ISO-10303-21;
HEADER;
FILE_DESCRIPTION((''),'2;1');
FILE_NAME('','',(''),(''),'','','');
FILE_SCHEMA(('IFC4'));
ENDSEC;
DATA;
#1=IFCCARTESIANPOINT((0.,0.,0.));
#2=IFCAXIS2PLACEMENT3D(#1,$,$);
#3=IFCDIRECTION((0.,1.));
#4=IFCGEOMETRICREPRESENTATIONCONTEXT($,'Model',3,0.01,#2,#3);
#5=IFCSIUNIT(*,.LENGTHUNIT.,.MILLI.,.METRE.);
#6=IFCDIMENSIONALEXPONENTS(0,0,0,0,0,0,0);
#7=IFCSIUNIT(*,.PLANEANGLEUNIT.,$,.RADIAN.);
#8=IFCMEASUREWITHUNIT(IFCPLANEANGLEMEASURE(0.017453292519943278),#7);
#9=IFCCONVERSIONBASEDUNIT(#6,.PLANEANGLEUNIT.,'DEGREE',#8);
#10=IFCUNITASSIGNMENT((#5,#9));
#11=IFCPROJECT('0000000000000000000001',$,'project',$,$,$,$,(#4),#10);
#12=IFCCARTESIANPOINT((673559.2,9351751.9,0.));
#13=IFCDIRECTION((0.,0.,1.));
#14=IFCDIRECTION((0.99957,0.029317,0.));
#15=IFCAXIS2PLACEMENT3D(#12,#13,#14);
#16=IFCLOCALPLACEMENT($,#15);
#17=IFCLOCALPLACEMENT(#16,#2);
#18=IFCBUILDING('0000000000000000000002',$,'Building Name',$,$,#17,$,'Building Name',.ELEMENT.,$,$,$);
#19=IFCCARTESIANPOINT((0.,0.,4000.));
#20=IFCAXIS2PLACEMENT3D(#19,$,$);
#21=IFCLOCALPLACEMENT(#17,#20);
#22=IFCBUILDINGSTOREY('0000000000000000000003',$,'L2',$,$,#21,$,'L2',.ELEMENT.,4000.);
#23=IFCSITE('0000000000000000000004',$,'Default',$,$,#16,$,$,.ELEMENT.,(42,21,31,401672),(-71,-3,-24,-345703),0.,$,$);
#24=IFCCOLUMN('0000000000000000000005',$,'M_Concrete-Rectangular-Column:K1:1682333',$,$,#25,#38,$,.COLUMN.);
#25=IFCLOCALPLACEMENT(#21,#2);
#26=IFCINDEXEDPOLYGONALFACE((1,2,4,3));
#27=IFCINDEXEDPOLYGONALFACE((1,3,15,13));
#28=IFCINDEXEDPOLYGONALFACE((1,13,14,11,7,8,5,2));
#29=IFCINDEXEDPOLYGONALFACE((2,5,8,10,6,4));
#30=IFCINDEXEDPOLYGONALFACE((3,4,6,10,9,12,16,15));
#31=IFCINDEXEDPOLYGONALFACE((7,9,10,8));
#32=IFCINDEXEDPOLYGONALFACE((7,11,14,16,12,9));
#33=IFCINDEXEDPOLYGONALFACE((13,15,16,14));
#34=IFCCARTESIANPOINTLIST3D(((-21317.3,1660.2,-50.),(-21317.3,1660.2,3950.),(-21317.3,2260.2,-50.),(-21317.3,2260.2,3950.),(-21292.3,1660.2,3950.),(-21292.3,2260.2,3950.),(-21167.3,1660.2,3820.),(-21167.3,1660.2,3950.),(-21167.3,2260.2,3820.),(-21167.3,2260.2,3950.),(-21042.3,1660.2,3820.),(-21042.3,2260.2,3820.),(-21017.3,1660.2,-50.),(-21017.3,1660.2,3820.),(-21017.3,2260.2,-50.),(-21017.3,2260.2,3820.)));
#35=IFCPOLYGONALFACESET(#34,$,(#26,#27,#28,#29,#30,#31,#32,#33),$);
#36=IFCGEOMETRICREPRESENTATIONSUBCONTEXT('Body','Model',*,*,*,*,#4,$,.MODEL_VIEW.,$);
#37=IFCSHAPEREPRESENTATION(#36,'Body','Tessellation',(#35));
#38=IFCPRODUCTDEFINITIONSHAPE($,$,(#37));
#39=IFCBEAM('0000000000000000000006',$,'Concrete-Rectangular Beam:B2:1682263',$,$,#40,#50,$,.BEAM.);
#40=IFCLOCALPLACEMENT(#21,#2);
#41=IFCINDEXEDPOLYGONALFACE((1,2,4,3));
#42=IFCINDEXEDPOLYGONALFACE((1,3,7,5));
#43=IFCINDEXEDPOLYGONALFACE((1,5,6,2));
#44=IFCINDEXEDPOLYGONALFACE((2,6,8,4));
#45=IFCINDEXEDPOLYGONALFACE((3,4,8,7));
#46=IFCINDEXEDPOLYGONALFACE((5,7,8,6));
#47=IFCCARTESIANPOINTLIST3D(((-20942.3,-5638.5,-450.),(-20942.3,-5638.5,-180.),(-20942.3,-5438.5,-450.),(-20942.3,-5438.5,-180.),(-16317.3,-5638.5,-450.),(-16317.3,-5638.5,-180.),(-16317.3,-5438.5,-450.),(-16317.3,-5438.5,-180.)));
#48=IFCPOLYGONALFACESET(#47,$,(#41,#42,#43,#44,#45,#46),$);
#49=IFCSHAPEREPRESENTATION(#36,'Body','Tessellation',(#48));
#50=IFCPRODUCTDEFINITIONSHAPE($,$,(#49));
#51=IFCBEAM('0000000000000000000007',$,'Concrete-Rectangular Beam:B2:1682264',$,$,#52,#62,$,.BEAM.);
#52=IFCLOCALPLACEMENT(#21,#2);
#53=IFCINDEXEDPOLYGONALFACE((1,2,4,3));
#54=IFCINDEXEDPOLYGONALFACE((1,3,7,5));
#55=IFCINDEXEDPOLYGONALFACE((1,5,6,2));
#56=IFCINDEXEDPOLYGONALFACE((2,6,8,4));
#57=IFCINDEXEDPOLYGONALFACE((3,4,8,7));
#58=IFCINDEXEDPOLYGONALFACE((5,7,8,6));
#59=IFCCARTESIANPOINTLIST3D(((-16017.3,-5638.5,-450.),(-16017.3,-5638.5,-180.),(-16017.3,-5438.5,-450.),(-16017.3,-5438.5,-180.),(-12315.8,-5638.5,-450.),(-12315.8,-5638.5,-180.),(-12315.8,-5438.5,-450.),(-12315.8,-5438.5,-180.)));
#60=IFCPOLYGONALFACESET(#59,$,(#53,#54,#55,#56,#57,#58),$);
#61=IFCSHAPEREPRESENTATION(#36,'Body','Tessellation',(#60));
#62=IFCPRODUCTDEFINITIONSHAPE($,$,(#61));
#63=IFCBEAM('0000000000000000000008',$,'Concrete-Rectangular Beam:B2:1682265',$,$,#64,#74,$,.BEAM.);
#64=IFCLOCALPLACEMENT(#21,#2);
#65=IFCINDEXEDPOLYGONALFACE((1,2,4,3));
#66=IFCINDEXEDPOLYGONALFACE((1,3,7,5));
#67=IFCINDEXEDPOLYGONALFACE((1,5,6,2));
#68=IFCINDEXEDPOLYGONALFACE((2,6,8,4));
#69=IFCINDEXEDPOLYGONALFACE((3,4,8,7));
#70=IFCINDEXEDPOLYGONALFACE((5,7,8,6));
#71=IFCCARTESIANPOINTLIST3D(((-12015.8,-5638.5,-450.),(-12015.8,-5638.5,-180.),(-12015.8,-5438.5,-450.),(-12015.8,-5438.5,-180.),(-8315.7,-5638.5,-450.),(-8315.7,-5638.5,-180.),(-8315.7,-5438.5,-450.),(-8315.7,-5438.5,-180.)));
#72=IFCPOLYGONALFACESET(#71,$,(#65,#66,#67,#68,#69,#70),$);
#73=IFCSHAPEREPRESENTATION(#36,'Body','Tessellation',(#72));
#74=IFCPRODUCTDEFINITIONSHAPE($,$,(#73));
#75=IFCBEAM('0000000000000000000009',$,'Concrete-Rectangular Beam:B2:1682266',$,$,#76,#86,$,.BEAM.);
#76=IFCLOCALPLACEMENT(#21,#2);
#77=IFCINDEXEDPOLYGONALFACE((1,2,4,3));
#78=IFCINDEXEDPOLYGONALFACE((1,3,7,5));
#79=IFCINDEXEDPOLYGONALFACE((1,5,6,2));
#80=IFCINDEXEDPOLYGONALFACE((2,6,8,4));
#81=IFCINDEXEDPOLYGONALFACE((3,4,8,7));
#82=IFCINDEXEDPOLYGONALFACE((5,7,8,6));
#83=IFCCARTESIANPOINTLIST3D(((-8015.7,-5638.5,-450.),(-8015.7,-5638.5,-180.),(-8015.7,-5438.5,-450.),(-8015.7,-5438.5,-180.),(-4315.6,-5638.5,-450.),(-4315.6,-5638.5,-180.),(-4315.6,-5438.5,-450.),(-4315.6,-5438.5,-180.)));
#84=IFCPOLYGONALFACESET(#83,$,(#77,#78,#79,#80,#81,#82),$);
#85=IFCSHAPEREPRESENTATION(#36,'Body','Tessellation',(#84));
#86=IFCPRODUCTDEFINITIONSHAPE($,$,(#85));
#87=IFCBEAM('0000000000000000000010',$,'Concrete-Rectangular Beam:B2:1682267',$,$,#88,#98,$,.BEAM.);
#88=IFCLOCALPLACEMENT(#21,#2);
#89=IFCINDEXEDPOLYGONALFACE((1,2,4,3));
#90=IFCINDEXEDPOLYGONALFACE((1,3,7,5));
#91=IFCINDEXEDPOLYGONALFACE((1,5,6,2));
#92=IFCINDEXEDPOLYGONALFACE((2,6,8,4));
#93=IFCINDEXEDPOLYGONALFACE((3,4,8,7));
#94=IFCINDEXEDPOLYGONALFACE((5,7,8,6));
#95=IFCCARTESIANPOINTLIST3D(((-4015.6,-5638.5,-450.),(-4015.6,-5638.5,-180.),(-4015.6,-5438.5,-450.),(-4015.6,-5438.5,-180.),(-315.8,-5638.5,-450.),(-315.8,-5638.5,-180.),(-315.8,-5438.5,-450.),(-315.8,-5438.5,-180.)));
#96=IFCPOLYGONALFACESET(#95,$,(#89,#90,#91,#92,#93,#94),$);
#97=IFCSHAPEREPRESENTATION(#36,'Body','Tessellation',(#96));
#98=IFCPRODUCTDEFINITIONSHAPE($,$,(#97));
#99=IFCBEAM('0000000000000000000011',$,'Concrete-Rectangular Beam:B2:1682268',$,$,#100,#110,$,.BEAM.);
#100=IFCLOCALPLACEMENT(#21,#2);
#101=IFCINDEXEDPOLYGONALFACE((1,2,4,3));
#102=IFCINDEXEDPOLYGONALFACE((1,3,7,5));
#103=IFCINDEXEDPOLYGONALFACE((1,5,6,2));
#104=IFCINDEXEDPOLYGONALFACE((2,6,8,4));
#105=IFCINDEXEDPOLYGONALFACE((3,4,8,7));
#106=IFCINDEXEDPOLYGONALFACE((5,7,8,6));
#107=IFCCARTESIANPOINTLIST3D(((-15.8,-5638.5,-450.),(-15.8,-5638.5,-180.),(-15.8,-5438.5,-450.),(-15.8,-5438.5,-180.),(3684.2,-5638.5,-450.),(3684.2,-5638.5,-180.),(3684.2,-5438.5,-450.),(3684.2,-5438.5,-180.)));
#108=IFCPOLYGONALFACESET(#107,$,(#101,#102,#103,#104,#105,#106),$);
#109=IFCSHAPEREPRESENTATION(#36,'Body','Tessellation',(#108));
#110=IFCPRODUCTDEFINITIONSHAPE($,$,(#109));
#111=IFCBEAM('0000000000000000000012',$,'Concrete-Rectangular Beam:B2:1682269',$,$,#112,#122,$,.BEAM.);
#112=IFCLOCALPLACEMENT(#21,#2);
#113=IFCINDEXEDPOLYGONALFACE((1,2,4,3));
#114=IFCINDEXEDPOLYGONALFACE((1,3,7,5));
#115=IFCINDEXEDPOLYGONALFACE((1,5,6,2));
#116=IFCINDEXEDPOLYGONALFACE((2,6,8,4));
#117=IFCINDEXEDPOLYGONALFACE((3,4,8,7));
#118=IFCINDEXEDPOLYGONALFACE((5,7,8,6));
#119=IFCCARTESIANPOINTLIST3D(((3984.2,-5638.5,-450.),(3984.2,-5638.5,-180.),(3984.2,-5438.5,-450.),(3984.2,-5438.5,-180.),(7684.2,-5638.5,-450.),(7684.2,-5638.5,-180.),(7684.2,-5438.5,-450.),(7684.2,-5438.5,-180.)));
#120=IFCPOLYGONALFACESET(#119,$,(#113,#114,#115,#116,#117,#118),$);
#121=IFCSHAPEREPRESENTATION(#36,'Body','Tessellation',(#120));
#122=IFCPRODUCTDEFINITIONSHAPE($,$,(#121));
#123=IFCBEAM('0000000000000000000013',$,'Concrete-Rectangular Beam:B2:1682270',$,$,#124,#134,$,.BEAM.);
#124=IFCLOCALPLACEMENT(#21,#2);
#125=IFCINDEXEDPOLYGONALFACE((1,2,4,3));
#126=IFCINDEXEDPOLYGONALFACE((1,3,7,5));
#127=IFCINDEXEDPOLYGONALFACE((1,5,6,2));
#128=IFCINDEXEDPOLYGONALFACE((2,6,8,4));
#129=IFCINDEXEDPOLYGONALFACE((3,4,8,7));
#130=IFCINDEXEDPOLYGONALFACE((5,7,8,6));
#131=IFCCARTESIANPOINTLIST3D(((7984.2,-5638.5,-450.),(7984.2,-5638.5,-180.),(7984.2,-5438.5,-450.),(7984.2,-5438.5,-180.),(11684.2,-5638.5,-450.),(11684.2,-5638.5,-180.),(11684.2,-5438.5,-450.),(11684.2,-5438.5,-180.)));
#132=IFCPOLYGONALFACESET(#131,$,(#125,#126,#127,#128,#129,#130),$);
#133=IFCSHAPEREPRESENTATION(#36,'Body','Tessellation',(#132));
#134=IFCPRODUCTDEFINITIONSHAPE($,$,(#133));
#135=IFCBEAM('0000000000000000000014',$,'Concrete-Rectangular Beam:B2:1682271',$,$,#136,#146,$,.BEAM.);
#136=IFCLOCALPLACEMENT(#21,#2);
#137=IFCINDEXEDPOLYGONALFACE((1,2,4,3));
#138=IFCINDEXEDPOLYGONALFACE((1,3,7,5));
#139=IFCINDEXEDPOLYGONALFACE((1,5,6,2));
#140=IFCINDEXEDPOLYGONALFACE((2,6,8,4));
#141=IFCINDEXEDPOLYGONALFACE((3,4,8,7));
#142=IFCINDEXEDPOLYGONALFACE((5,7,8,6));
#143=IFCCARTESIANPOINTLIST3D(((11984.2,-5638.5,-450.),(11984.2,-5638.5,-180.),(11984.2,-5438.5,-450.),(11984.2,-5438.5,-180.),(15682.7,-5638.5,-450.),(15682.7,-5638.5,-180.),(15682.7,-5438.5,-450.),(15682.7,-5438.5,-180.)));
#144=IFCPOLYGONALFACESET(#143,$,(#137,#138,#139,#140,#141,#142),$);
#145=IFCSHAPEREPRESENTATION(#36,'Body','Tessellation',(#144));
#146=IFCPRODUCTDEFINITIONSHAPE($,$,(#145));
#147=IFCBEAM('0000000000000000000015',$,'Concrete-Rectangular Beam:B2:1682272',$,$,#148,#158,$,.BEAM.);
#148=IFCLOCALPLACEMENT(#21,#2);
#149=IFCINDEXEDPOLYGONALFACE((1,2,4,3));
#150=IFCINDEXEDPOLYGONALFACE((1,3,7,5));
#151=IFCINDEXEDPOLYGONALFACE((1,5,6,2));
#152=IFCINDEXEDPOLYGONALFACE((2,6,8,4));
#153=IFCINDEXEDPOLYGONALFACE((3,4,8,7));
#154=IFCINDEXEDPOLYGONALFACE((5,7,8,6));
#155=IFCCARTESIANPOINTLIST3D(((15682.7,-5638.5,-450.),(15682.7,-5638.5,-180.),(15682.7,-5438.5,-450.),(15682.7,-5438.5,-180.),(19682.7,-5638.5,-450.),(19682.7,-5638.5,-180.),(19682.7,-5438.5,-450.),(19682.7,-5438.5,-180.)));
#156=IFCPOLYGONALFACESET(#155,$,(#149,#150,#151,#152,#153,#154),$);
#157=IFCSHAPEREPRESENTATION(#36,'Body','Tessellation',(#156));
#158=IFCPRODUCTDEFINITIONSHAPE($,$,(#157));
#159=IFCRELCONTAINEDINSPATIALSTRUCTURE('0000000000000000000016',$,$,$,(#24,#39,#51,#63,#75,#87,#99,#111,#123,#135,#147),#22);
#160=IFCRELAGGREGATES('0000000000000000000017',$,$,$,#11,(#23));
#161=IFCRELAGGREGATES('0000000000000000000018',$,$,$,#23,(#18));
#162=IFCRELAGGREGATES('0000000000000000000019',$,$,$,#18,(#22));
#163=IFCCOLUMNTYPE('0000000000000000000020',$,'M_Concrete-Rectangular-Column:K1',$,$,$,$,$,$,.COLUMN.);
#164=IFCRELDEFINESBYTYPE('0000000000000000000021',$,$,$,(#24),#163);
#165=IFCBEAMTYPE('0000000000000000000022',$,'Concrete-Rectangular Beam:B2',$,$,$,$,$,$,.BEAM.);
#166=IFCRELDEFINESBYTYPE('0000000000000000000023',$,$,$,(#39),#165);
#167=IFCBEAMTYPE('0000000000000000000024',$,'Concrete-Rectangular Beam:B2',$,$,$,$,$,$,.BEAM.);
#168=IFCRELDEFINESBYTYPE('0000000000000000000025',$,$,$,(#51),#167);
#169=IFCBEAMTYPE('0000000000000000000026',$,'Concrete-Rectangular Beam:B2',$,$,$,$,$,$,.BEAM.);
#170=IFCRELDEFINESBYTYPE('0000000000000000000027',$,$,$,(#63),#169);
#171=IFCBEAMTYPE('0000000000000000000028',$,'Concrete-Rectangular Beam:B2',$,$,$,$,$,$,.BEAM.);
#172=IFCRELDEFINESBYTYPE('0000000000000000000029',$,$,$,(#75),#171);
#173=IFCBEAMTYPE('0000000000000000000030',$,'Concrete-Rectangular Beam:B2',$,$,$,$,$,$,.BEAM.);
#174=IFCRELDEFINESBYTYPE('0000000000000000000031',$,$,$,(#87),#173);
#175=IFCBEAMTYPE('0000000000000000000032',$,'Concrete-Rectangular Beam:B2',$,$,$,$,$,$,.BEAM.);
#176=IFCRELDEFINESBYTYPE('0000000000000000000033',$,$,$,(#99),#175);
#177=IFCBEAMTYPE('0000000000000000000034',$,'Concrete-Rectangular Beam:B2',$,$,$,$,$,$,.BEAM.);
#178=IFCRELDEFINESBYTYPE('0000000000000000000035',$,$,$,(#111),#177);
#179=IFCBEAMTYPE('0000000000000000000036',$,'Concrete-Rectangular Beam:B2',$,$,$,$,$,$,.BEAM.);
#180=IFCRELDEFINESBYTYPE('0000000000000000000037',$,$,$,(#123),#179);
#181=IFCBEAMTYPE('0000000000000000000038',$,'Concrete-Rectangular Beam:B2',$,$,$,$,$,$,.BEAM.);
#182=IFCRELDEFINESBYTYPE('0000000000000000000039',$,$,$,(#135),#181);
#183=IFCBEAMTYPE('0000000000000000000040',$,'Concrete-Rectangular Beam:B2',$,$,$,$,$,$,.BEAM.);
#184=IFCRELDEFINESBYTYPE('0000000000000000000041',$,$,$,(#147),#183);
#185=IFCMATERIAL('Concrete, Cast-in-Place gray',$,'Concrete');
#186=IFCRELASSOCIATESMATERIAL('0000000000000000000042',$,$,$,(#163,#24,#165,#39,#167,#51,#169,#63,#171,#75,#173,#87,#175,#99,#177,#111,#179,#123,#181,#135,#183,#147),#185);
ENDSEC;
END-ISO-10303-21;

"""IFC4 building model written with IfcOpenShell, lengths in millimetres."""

from ifc_helpers import new_model, entity, si_unit, converted_unit, direction, frame, origin, place, context, subcontext, project, spatial, indexed_curve, outline, extrude, source, transform, mapped, material, type_object, type_shapes, element, save


model = new_model("IFC4")

# Units and contexts
model_context = context("Model", 3, precision=0.01, world=origin(), true_north=direction((0.0, 1.0)))
body_context = subcontext(model_context, "Body", "Model", "MODEL_VIEW")
ifc_project = project(units=[si_unit("LENGTHUNIT", "METRE", prefix="MILLI"), converted_unit("PLANEANGLEUNIT", "DEGREE", entity("IfcPlaneAngleMeasure", 0.017453292519943278), si_unit("PLANEANGLEUNIT", "RADIAN"), dimensions=[0, 0, 0, 0, 0, 0, 0])], contexts=[model_context])

# Site, building, storey
site_placement = place(None, frame((673559.2, 9351751.9, 0.0), z_axis=(0.0, 0.0, 1.0), x_axis=(0.99957, 0.029317, 0.0)))
site = spatial("IfcSite", under=ifc_project, at=site_placement, Name="Default", CompositionType="ELEMENT", RefLatitude=(42, 21, 31, 401672), RefLongitude=(-71, -3, -24, -345703), RefElevation=0.0)
building_placement = place(site_placement, origin())
building = spatial("IfcBuilding", under=site, at=building_placement, Name="Building Name", LongName="Building Name", CompositionType="ELEMENT")
storey_placement = place(building_placement, frame((0.0, 0.0, 4000.0)))
storey = spatial("IfcBuildingStorey", under=building, at=storey_placement, Name="L2", LongName="L2", CompositionType="ELEMENT", Elevation=4000.0)

# Column
ifc_material = material(Name="Concrete, Cast-in-Place gray", Category="Concrete")
column_type = type_object("IfcColumnType", Name="M_Concrete-Rectangular-Column:K1", PredefinedType="COLUMN", material=ifc_material)
shared_shape_1 = source(origin(), body_context, "Body", "SweptSolid", [
    extrude(outline(indexed_curve([(-2951.3, -150.0), (1048.7, -150.0), (1048.7, -125.0), (1048.7, 0.0), (918.8, 0.0), (918.8, 125.0), (918.8, 150.0), (-2951.3, 150.0), (-2951.3, -150.0)], self_intersect=False)), frame((-21167.3, 1660.2, 6901.3), z_axis=(0.0, 1.0, 0.0), x_axis=(0.0, 0.0, 1.0)), (0.0, 0.0, 1.0), 600.0),
])
type_shapes(column_type, [shared_shape_1])
column_placement = place(storey_placement, frame((0.0, 0.0, -4000.0)))
element("IfcColumn", 1, at=column_placement, inside=storey, type_object=column_type, material=ifc_material, Name="M_Concrete-Rectangular-Column:K1:1682333", PredefinedType="COLUMN", context=body_context, shape_type="MappedRepresentation", body=[
    mapped(shared_shape_1, transform((0.0, 0.0, 0.0), scale=1.0)),
])

# Beams
beam_type_1 = type_object("IfcBeamType", Name="Concrete-Rectangular Beam:B2", PredefinedType="BEAM", material=ifc_material)
shared_shape_2 = source(origin(), body_context, "Body", "SweptSolid", [
    extrude(outline(indexed_curve([(-135.0, -100.0), (135.0, -100.0), (135.0, 100.0), (-135.0, 100.0), (-135.0, -100.0)], self_intersect=False)), frame((-20942.3, -5538.5, 3685.0), z_axis=(1.0, 0.0, 0.0), x_axis=(0.0, 0.0, -1.0)), (0.0, 0.0, 1.0), 4625.0),
])
type_shapes(beam_type_1, [shared_shape_2])
beam_1_placement = place(storey_placement, frame((0.0, 0.0, -4000.0)))
element("IfcBeam", 2, at=beam_1_placement, inside=storey, type_object=beam_type_1, material=ifc_material, Name="Concrete-Rectangular Beam:B2:1682263", PredefinedType="BEAM", context=body_context, shape_type="MappedRepresentation", body=[
    mapped(shared_shape_2, transform((0.0, 0.0, 0.0), scale=1.0)),
])
beam_type_2 = type_object("IfcBeamType", Name="Concrete-Rectangular Beam:B2", PredefinedType="BEAM", material=ifc_material)
shared_shape_3 = source(origin(), body_context, "Body", "SweptSolid", [
    extrude(outline(indexed_curve([(-135.0, -100.0), (135.0, -100.0), (135.0, 100.0), (-135.0, 100.0), (-135.0, -100.0)], self_intersect=False)), frame((-16017.3, -5538.5, 3685.0), z_axis=(1.0, 0.0, 0.0), x_axis=(0.0, 0.0, -1.0)), (0.0, 0.0, 1.0), 3701.5),
])
type_shapes(beam_type_2, [shared_shape_3])
beam_2_placement = place(storey_placement, frame((0.0, 0.0, -4000.0)))
element("IfcBeam", 3, at=beam_2_placement, inside=storey, type_object=beam_type_2, material=ifc_material, Name="Concrete-Rectangular Beam:B2:1682264", PredefinedType="BEAM", context=body_context, shape_type="MappedRepresentation", body=[
    mapped(shared_shape_3, transform((0.0, 0.0, 0.0), scale=1.0)),
])
beam_type_3 = type_object("IfcBeamType", Name="Concrete-Rectangular Beam:B2", PredefinedType="BEAM", material=ifc_material)
shared_shape_4 = source(origin(), body_context, "Body", "SweptSolid", [
    extrude(outline(indexed_curve([(-135.0, -100.0), (135.0, -100.0), (135.0, 100.0), (-135.0, 100.0), (-135.0, -100.0)], self_intersect=False)), frame((-8315.7, -5538.5, 3685.0), z_axis=(-1.0, 0.0, 0.0), x_axis=(0.0, 0.0, -1.0)), (0.0, 0.0, 1.0), 3700.1),
])
type_shapes(beam_type_3, [shared_shape_4])
beam_3_placement = place(storey_placement, frame((0.0, 0.0, -4000.0)))
element("IfcBeam", 4, at=beam_3_placement, inside=storey, type_object=beam_type_3, material=ifc_material, Name="Concrete-Rectangular Beam:B2:1682265", PredefinedType="BEAM", context=body_context, shape_type="MappedRepresentation", body=[
    mapped(shared_shape_4, transform((0.0, 0.0, 0.0), scale=1.0)),
])
beam_type_4 = type_object("IfcBeamType", Name="Concrete-Rectangular Beam:B2", PredefinedType="BEAM", material=ifc_material)
shared_shape_5 = source(origin(), body_context, "Body", "SweptSolid", [
    extrude(outline(indexed_curve([(-135.0, -100.0), (135.0, -100.0), (135.0, 100.0), (-135.0, 100.0), (-135.0, -100.0)], self_intersect=False)), frame((-8015.7, -5538.5, 3685.0), z_axis=(1.0, 0.0, 0.0), x_axis=(0.0, 0.0, -1.0)), (0.0, 0.0, 1.0), 3700.1),
])
type_shapes(beam_type_4, [shared_shape_5])
beam_4_placement = place(storey_placement, frame((0.0, 0.0, -4000.0)))
element("IfcBeam", 5, at=beam_4_placement, inside=storey, type_object=beam_type_4, material=ifc_material, Name="Concrete-Rectangular Beam:B2:1682266", PredefinedType="BEAM", context=body_context, shape_type="MappedRepresentation", body=[
    mapped(shared_shape_5, transform((0.0, 0.0, 0.0), scale=1.0)),
])
beam_type_5 = type_object("IfcBeamType", Name="Concrete-Rectangular Beam:B2", PredefinedType="BEAM", material=ifc_material)
shared_shape_6 = source(origin(), body_context, "Body", "SweptSolid", [
    extrude(outline(indexed_curve([(-135.0, -100.0), (135.0, -100.0), (135.0, 100.0), (-135.0, 100.0), (-135.0, -100.0)], self_intersect=False)), frame((-4015.6, -5538.5, 3685.0), z_axis=(1.0, 0.0, 0.0), x_axis=(0.0, 0.0, -1.0)), (0.0, 0.0, 1.0), 3699.7),
])
type_shapes(beam_type_5, [shared_shape_6])
beam_5_placement = place(storey_placement, frame((0.0, 0.0, -4000.0)))
element("IfcBeam", 6, at=beam_5_placement, inside=storey, type_object=beam_type_5, material=ifc_material, Name="Concrete-Rectangular Beam:B2:1682267", PredefinedType="BEAM", context=body_context, shape_type="MappedRepresentation", body=[
    mapped(shared_shape_6, transform((0.0, 0.0, 0.0), scale=1.0)),
])
beam_type_6 = type_object("IfcBeamType", Name="Concrete-Rectangular Beam:B2", PredefinedType="BEAM", material=ifc_material)
shared_shape_7 = source(origin(), body_context, "Body", "SweptSolid", [
    extrude(outline(indexed_curve([(-135.0, -100.0), (135.0, -100.0), (135.0, 100.0), (-135.0, 100.0), (-135.0, -100.0)], self_intersect=False)), frame((-15.8, -5538.5, 3685.0), z_axis=(1.0, 0.0, 0.0), x_axis=(0.0, 0.0, -1.0)), (0.0, 0.0, 1.0), 3700.0),
])
type_shapes(beam_type_6, [shared_shape_7])
beam_6_placement = place(storey_placement, frame((0.0, 0.0, -4000.0)))
element("IfcBeam", 7, at=beam_6_placement, inside=storey, type_object=beam_type_6, material=ifc_material, Name="Concrete-Rectangular Beam:B2:1682268", PredefinedType="BEAM", context=body_context, shape_type="MappedRepresentation", body=[
    mapped(shared_shape_7, transform((0.0, 0.0, 0.0), scale=1.0)),
])
beam_type_7 = type_object("IfcBeamType", Name="Concrete-Rectangular Beam:B2", PredefinedType="BEAM", material=ifc_material)
shared_shape_8 = source(origin(), body_context, "Body", "SweptSolid", [
    extrude(outline(indexed_curve([(-135.0, -100.0), (135.0, -100.0), (135.0, 100.0), (-135.0, 100.0), (-135.0, -100.0)], self_intersect=False)), frame((3984.2, -5538.5, 3685.0), z_axis=(1.0, 0.0, 0.0), x_axis=(0.0, 0.0, -1.0)), (0.0, 0.0, 1.0), 3700.0),
])
type_shapes(beam_type_7, [shared_shape_8])
beam_7_placement = place(storey_placement, frame((0.0, 0.0, -4000.0)))
element("IfcBeam", 8, at=beam_7_placement, inside=storey, type_object=beam_type_7, material=ifc_material, Name="Concrete-Rectangular Beam:B2:1682269", PredefinedType="BEAM", context=body_context, shape_type="MappedRepresentation", body=[
    mapped(shared_shape_8, transform((0.0, 0.0, 0.0), scale=1.0)),
])
beam_type_8 = type_object("IfcBeamType", Name="Concrete-Rectangular Beam:B2", PredefinedType="BEAM", material=ifc_material)
shared_shape_9 = source(origin(), body_context, "Body", "SweptSolid", [
    extrude(outline(indexed_curve([(-135.0, -100.0), (135.0, -100.0), (135.0, 100.0), (-135.0, 100.0), (-135.0, -100.0)], self_intersect=False)), frame((7984.2, -5538.5, 3685.0), z_axis=(1.0, 0.0, 0.0), x_axis=(0.0, 0.0, -1.0)), (0.0, 0.0, 1.0), 3700.0),
])
type_shapes(beam_type_8, [shared_shape_9])
beam_8_placement = place(storey_placement, frame((0.0, 0.0, -4000.0)))
element("IfcBeam", 9, at=beam_8_placement, inside=storey, type_object=beam_type_8, material=ifc_material, Name="Concrete-Rectangular Beam:B2:1682270", PredefinedType="BEAM", context=body_context, shape_type="MappedRepresentation", body=[
    mapped(shared_shape_9, transform((0.0, 0.0, 0.0), scale=1.0)),
])
beam_type_9 = type_object("IfcBeamType", Name="Concrete-Rectangular Beam:B2", PredefinedType="BEAM", material=ifc_material)
shared_shape_10 = source(origin(), body_context, "Body", "SweptSolid", [
    extrude(outline(indexed_curve([(-135.0, -100.0), (135.0, -100.0), (135.0, 100.0), (-135.0, 100.0), (-135.0, -100.0)], self_intersect=False)), frame((11984.2, -5538.5, 3685.0), z_axis=(1.0, 0.0, 0.0), x_axis=(0.0, 0.0, -1.0)), (0.0, 0.0, 1.0), 3698.5),
])
type_shapes(beam_type_9, [shared_shape_10])
beam_9_placement = place(storey_placement, frame((0.0, 0.0, -4000.0)))
element("IfcBeam", 10, at=beam_9_placement, inside=storey, type_object=beam_type_9, material=ifc_material, Name="Concrete-Rectangular Beam:B2:1682271", PredefinedType="BEAM", context=body_context, shape_type="MappedRepresentation", body=[
    mapped(shared_shape_10, transform((0.0, 0.0, 0.0), scale=1.0)),
])
beam_type_10 = type_object("IfcBeamType", Name="Concrete-Rectangular Beam:B2", PredefinedType="BEAM", material=ifc_material)
shared_shape_11 = source(origin(), body_context, "Body", "SweptSolid", [
    extrude(outline(indexed_curve([(-135.0, -100.0), (135.0, -100.0), (135.0, 100.0), (-135.0, 100.0), (-135.0, -100.0)], self_intersect=False)), frame((15682.7, -5538.5, 3685.0), z_axis=(1.0, 0.0, 0.0), x_axis=(0.0, 0.0, -1.0)), (0.0, 0.0, 1.0), 4000.0),
])
type_shapes(beam_type_10, [shared_shape_11])
beam_10_placement = place(storey_placement, frame((0.0, 0.0, -4000.0)))
element("IfcBeam", 11, at=beam_10_placement, inside=storey, type_object=beam_type_10, material=ifc_material, Name="Concrete-Rectangular Beam:B2:1682272", PredefinedType="BEAM", context=body_context, shape_type="MappedRepresentation", body=[
    mapped(shared_shape_11, transform((0.0, 0.0, 0.0), scale=1.0)),
])

save(model, "model.ifc")
